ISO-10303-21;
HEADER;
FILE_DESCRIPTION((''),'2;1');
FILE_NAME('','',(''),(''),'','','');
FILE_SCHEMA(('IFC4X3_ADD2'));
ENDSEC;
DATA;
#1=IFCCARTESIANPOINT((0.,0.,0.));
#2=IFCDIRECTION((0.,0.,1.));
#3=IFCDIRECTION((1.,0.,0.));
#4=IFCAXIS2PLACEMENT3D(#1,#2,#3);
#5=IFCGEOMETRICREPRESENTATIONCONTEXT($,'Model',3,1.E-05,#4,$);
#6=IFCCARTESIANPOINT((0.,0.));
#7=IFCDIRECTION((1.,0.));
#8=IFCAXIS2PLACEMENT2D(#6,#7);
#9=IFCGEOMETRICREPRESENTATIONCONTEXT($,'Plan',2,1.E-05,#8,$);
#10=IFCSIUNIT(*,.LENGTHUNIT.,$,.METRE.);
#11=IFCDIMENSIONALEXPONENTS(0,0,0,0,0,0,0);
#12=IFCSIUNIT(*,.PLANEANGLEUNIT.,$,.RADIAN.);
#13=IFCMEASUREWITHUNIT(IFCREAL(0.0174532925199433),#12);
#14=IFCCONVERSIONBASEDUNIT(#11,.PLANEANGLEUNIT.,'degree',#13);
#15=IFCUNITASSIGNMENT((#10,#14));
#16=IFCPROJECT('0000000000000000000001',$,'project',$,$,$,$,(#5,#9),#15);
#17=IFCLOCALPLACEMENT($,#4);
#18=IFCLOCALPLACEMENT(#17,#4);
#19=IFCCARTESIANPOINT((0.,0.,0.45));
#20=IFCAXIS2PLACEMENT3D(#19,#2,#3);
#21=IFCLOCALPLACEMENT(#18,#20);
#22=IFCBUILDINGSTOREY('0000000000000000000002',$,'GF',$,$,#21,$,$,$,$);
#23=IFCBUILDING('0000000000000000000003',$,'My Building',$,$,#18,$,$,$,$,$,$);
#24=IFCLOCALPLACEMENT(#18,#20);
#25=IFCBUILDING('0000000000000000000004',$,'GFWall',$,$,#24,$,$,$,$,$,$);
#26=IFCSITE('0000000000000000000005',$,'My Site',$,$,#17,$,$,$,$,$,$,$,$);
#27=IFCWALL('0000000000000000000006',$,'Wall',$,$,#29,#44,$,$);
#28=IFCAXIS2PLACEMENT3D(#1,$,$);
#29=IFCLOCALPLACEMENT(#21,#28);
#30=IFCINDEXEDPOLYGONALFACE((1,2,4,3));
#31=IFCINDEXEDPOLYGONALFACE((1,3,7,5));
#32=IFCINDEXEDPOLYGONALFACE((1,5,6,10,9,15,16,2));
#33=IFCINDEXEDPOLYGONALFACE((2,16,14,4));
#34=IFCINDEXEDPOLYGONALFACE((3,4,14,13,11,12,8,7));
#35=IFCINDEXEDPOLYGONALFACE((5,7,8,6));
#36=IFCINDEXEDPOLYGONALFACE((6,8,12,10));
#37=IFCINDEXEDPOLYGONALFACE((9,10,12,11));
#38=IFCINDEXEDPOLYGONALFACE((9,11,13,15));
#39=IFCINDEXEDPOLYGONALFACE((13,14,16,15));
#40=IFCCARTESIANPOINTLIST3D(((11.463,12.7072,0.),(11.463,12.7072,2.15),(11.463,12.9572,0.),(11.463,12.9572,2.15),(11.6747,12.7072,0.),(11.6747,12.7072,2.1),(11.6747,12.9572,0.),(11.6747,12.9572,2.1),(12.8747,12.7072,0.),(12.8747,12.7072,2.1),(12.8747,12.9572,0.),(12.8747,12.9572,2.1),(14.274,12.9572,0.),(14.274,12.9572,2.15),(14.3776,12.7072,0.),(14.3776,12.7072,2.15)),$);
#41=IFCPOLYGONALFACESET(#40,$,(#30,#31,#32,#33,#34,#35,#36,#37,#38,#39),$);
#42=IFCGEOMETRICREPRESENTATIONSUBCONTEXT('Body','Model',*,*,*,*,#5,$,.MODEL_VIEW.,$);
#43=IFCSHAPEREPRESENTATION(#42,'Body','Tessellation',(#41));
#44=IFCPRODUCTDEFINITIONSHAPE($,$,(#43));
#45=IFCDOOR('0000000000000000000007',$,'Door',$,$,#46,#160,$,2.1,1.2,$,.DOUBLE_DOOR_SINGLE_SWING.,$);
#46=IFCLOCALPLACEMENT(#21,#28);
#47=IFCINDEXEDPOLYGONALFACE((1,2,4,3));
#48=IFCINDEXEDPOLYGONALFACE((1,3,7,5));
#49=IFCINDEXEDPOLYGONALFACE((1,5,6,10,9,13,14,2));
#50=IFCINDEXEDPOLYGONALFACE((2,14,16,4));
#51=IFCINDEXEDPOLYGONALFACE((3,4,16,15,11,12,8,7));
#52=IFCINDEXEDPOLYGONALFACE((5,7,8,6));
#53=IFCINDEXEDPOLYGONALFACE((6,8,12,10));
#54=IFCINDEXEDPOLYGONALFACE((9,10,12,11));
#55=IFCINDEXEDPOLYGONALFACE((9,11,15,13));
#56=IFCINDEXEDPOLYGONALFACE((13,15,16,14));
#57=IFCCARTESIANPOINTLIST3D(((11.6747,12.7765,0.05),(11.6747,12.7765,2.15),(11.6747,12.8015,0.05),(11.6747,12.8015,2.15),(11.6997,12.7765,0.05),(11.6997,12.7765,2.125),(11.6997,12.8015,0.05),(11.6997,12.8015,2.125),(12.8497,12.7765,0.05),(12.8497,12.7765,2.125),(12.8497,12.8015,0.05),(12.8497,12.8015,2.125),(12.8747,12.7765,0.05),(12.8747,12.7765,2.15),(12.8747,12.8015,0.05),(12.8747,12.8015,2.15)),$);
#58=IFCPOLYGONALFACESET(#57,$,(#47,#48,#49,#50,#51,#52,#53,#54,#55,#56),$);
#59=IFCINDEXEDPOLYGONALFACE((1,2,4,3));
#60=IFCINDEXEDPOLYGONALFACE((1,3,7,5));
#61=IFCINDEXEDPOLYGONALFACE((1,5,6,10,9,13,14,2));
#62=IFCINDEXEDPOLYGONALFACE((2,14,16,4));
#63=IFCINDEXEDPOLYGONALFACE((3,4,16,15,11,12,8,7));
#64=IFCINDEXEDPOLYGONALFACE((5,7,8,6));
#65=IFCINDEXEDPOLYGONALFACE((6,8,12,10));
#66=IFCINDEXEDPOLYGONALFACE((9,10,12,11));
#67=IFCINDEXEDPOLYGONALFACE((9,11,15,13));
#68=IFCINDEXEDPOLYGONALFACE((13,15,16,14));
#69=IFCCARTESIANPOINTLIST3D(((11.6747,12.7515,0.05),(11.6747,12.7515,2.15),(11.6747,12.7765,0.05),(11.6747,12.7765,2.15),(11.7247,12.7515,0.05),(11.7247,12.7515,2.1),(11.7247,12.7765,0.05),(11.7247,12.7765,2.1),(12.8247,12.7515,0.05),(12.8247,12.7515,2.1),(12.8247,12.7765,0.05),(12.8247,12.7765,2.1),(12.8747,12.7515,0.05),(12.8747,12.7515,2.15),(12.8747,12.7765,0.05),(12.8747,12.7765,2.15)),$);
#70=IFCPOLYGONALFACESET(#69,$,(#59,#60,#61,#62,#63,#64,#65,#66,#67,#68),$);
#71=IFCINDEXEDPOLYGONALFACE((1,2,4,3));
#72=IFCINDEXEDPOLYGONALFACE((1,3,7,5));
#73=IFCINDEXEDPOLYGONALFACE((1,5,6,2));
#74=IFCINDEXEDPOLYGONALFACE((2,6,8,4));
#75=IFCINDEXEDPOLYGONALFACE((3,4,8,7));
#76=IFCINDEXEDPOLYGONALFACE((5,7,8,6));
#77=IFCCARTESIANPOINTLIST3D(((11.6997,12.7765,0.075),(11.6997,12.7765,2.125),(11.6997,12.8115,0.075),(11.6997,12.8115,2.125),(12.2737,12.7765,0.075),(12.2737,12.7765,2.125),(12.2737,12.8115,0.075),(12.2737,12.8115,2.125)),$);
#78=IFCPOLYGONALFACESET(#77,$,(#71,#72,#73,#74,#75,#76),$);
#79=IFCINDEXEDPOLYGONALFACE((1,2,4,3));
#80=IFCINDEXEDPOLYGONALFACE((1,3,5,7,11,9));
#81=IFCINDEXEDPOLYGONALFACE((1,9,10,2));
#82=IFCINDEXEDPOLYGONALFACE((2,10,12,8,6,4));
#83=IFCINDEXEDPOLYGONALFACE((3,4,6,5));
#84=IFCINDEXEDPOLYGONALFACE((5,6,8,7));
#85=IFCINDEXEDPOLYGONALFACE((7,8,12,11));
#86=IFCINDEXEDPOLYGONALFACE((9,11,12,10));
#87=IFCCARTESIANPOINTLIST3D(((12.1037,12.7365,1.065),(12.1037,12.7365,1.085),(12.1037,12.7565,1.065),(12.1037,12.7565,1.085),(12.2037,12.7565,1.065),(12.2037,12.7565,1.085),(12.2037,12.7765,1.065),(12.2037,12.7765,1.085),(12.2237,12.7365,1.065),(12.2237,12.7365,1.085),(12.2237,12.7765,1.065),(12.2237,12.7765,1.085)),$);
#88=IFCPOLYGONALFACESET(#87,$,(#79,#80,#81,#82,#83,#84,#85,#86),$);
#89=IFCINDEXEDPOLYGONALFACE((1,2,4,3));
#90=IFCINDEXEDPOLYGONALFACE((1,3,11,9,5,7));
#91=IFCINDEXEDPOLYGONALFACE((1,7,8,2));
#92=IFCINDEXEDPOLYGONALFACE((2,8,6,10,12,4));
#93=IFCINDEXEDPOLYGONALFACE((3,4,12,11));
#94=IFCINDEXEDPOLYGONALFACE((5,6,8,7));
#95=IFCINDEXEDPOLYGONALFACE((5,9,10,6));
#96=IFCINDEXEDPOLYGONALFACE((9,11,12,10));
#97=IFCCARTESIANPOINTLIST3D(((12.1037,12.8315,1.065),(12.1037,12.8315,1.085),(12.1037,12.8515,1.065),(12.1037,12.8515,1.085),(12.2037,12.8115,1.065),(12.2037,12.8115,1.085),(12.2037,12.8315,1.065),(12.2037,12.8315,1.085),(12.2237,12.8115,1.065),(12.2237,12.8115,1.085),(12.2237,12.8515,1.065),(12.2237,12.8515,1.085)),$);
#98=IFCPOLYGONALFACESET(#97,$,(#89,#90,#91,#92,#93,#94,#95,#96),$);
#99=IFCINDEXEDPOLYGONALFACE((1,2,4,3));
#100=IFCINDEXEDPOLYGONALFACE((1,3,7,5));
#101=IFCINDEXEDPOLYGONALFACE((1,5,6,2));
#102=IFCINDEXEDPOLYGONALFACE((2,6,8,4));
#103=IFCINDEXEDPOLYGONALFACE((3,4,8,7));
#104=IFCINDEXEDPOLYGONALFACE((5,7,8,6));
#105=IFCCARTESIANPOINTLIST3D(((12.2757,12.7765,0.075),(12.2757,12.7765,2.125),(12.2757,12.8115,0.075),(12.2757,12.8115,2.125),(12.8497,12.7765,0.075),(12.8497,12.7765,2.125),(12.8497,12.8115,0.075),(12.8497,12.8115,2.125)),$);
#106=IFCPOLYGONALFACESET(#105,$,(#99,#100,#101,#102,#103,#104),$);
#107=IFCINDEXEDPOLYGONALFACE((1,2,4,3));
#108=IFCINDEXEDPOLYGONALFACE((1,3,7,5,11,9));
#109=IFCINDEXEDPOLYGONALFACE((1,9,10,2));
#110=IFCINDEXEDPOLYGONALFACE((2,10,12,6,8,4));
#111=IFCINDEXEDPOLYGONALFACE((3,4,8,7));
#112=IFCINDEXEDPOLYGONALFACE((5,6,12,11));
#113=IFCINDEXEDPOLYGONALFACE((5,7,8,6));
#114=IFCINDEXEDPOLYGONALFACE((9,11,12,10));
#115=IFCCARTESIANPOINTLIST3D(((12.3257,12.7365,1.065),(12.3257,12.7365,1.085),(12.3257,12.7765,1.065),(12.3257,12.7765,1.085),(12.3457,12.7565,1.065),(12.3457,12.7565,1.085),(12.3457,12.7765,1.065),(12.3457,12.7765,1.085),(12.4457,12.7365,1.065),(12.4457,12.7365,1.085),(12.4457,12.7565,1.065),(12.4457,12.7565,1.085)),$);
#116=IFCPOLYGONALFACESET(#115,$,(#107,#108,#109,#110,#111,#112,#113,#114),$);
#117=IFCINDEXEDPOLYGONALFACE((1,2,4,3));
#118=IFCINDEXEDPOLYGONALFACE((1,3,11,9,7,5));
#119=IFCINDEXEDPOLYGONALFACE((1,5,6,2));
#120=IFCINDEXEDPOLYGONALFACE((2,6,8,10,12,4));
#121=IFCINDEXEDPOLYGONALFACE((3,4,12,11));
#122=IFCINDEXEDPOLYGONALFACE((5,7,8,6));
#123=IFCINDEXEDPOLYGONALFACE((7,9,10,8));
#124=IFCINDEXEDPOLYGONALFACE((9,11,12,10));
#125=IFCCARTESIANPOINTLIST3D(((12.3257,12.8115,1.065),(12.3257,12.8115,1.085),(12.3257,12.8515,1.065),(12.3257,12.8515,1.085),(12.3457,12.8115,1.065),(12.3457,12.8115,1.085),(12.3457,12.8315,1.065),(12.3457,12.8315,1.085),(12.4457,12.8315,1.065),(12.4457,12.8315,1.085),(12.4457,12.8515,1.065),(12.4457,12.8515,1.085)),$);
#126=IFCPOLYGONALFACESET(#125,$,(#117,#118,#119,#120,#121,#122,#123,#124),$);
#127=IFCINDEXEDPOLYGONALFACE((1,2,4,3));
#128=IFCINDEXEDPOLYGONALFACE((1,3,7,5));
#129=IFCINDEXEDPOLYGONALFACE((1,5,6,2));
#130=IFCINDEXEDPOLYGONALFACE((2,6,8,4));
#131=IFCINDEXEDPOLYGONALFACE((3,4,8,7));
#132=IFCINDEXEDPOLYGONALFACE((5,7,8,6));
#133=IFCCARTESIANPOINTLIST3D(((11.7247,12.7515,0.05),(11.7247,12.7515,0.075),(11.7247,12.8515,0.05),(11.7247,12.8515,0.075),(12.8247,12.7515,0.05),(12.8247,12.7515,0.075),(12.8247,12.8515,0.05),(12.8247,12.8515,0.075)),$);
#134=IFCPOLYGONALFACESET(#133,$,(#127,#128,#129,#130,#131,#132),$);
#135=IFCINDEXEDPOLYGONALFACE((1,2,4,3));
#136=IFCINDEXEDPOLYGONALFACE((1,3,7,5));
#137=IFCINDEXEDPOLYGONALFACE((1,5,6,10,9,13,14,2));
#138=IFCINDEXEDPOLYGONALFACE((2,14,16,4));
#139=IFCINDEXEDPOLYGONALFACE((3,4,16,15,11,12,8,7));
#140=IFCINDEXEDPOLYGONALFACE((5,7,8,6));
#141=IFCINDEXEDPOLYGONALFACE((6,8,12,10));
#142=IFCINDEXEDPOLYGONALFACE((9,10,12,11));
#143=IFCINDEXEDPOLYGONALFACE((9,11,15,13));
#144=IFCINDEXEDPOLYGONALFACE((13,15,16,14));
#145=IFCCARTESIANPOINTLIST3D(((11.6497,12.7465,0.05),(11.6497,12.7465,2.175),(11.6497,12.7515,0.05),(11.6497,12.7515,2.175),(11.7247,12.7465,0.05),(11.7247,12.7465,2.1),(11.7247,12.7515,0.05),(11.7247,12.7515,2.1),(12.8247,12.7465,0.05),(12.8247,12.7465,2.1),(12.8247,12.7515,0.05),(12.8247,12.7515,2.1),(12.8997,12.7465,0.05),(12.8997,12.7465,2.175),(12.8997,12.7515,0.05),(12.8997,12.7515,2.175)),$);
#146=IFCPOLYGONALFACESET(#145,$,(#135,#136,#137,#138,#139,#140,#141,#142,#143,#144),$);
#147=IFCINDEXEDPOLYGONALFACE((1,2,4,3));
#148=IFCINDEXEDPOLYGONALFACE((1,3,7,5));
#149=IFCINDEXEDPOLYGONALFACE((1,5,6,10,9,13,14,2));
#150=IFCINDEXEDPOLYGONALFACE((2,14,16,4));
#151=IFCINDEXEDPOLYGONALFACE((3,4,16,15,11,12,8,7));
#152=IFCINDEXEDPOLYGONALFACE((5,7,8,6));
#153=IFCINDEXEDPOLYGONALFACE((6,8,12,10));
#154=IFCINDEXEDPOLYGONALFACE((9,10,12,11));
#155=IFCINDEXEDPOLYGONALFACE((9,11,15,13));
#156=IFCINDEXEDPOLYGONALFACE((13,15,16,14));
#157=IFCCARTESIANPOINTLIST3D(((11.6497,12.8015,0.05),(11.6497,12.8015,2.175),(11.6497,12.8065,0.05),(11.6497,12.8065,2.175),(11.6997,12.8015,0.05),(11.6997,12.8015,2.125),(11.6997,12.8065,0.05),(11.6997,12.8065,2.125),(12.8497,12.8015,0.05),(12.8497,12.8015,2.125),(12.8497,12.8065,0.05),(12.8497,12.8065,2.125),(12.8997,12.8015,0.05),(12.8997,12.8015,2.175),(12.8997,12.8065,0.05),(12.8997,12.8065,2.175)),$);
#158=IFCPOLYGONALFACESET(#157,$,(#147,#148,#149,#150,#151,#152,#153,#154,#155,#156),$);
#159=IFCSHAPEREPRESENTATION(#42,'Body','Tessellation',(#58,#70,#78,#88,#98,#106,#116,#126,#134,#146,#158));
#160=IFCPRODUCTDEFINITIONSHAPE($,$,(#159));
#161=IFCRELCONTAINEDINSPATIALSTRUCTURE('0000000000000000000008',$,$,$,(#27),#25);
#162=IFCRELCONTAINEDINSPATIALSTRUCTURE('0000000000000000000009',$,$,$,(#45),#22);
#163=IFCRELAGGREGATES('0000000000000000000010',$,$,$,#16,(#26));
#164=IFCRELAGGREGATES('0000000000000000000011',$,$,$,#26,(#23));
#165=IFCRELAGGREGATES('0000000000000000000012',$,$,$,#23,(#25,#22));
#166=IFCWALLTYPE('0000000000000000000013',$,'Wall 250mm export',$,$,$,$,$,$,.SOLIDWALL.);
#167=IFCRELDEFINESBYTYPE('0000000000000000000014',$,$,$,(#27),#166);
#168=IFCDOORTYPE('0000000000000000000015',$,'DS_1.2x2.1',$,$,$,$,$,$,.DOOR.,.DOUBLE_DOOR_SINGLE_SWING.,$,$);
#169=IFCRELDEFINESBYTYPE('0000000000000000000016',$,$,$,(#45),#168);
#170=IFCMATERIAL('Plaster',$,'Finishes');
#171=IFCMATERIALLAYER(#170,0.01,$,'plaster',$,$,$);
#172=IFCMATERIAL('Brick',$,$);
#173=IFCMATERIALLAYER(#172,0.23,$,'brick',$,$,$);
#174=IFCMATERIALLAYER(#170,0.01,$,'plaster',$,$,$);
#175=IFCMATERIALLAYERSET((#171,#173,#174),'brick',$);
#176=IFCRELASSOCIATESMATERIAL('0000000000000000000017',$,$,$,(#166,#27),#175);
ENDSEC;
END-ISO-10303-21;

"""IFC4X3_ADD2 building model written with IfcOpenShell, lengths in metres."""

from ifc_helpers import new_model, entity, si_unit, converted_unit, frame, origin_with_axes, origin_2d_with_axis, place, context, subcontext, project, spatial, line, indexed_curve, outline, extrude, shape, source, transform, mapped, material, layer, layer_set, layer_usage, type_object, type_shapes, element, fill, save


model = new_model("IFC4X3_ADD2")

# Units and contexts
model_context = context("Model", 3, precision=1e-05, world=origin_with_axes())
plan_context = context("Plan", 2, precision=1e-05, world=origin_2d_with_axis())
body_context_1 = subcontext(model_context, "Body", "Model", "MODEL_VIEW")
body_context_2 = subcontext(plan_context, "Body", "Plan", "PLAN_VIEW")
ifc_project = project(units=[si_unit("LENGTHUNIT", "METRE"), converted_unit("PLANEANGLEUNIT", "degree", entity("IfcReal", 0.0174532925199433), si_unit("PLANEANGLEUNIT", "RADIAN"), dimensions=[0, 0, 0, 0, 0, 0, 0])], contexts=[model_context, plan_context])

# Site, buildings
site_placement = place(None, origin_with_axes())
site = spatial("IfcSite", under=ifc_project, at=site_placement, Name="My Site")
building_1_placement = place(site_placement, origin_with_axes())
building_1 = spatial("IfcBuilding", under=site, at=building_1_placement, Name="My Building")
building_2_placement = place(building_1_placement, frame((0.0, 0.0, 0.45), z_axis=(0.0, 0.0, 1.0), x_axis=(1.0, 0.0, 0.0)))
building_2 = spatial("IfcBuilding", under=building_1, at=building_2_placement, Name="GFWall")

# Shared definitions
ifc_material_1 = material(Name="Plaster", Category="Finishes")

# Shared definitions
storey_placement = place(building_1_placement, frame((0.0, 0.0, 0.45), z_axis=(0.0, 0.0, 1.0), x_axis=(1.0, 0.0, 0.0)))
storey = spatial("IfcBuildingStorey", under=building_1, at=storey_placement, Name="GF")

# Shared definitions
ifc_layer_1 = layer(ifc_material_1, 0.01, Name="plaster")
ifc_material_2 = material(Name="Brick")
ifc_layer_2 = layer(ifc_material_2, 0.23, Name="brick")
ifc_layer_3 = layer(ifc_material_1, 0.01, Name="plaster")
ifc_layer_set_1 = layer_set([ifc_layer_1, ifc_layer_2, ifc_layer_3], Name="brick")
wall_type_1 = type_object("IfcWallType", Name="Wall 250mm export", PredefinedType="SOLIDWALL", material=ifc_layer_set_1)

# Wall, opening, door
shared_shape_1 = source(origin_with_axes(), body_context_1, "Body", "SweptSolid", [
    extrude(outline(indexed_curve([(0.0, 0.0), (1.2, 0.0), (1.2, 2.1), (0.0, 2.1)], segments=[line(1, 2, 3, 4, 1)])), frame((0.0, -0.6, 0.0), z_axis=(0.0, -1.0, 0.0), x_axis=(1.0, 0.0, 0.0)), (0.0, 0.0, -1.0), 1.2),
])
door_type_1 = type_object("IfcDoorType", Name="DS_1.2x2.1", OperationType="DOUBLE_DOOR_SINGLE_SWING", PredefinedType="DOOR")
shared_shape_2 = source(origin_with_axes(), body_context_1, "Body", "SweptSolid", [
    extrude(outline(indexed_curve([(0.0, 0.0), (0.0, 2.1), (1.2, 2.1), (1.2, 0.0), (1.175, 0.0), (1.175, 2.075), (0.025, 2.075), (0.025, 0.0)], segments=[line(1, 2, 3, 4, 5, 6, 7, 8, 1)])), frame((0.0, 0.025, 0.0), z_axis=(0.0, -1.0, 0.0), x_axis=(1.0, 0.0, 0.0)), (0.0, 0.0, -1.0), 0.025),
    extrude(outline(indexed_curve([(0.0, 0.0), (0.0, 2.1), (1.2, 2.1), (1.2, 0.0), (1.15, 0.0), (1.15, 2.05), (0.05, 2.05), (0.05, 0.0)], segments=[line(1, 2, 3, 4, 5, 6, 7, 8, 1)])), frame((0.0, 0.0, 0.0), z_axis=(0.0, -1.0, 0.0), x_axis=(1.0, 0.0, 0.0)), (0.0, 0.0, -1.0), 0.025),
    extrude(outline(indexed_curve([(0.0, 0.0), (0.574, 0.0), (0.574, 0.035), (0.0, 0.035)], segments=[line(1, 2, 3, 4, 1)])), frame((0.025, 0.025, 0.025), z_axis=(0.0, 0.0, 1.0), x_axis=(1.0, 0.0, 0.0)), (0.0, 0.0, 1.0), 2.05),
    extrude(outline(indexed_curve([(0.0, 0.0), (0.0, -0.04), (-0.12, -0.04), (-0.12, -0.02), (-0.02, -0.02), (-0.02, 0.0)], segments=[line(1, 2, 3, 4, 5, 6, 1)])), frame((0.549, 0.025, 1.015), z_axis=(0.0, 0.0, 1.0), x_axis=(1.0, 0.0, 0.0)), (0.0, 0.0, 1.0), 0.02),
    extrude(outline(indexed_curve([(0.0, 0.0), (0.0, 0.04), (-0.12, 0.04), (-0.12, 0.02), (-0.02, 0.02), (-0.02, 0.0)], segments=[line(1, 2, 3, 4, 5, 6, 1)])), frame((0.549, 0.06, 1.015), z_axis=(0.0, 0.0, 1.0), x_axis=(1.0, 0.0, 0.0)), (0.0, 0.0, 1.0), 0.02),
    extrude(outline(indexed_curve([(0.0, 0.0), (-0.574, 0.0), (-0.574, 0.035), (0.0, 0.035)], segments=[line(1, 2, 3, 4, 1)])), frame((1.175, 0.025, 0.025), z_axis=(0.0, 0.0, 1.0), x_axis=(1.0, 0.0, 0.0)), (0.0, 0.0, 1.0), 2.05),
    extrude(outline(indexed_curve([(0.0, 0.0), (0.0, -0.04), (0.12, -0.04), (0.12, -0.02), (0.02, -0.02), (0.02, 0.0)], segments=[line(1, 2, 3, 4, 5, 6, 1)])), frame((0.651, 0.025, 1.015), z_axis=(0.0, 0.0, 1.0), x_axis=(1.0, 0.0, 0.0)), (0.0, 0.0, 1.0), 0.02),
    extrude(outline(indexed_curve([(0.0, 0.0), (0.0, 0.04), (0.12, 0.04), (0.12, 0.02), (0.02, 0.02), (0.02, 0.0)], segments=[line(1, 2, 3, 4, 5, 6, 1)])), frame((0.651, 0.06, 1.015), z_axis=(0.0, 0.0, 1.0), x_axis=(1.0, 0.0, 0.0)), (0.0, 0.0, 1.0), 0.02),
    extrude(outline(indexed_curve([(0.0, 0.0), (1.1, 0.0), (1.1, 0.1), (0.0, 0.1)], segments=[line(1, 2, 3, 4, 1)])), frame((0.05, 0.0, 0.0), z_axis=(0.0, 0.0, 1.0), x_axis=(1.0, 0.0, 0.0)), (0.0, 0.0, 1.0), 0.025),
    extrude(outline(indexed_curve([(0.0, 0.0), (0.0, 2.125), (1.25, 2.125), (1.25, 0.0), (1.175, 0.0), (1.175, 2.05), (0.075, 2.05), (0.075, 0.0)], segments=[line(1, 2, 3, 4, 5, 6, 7, 8, 1)])), frame((-0.025, -0.005, 0.0), z_axis=(0.0, -1.0, 0.0), x_axis=(1.0, 0.0, 0.0)), (0.0, 0.0, -1.0), 0.005),
    extrude(outline(indexed_curve([(0.0, 0.0), (0.0, 2.125), (1.25, 2.125), (1.25, 0.0), (1.2, 0.0), (1.2, 2.075), (0.05, 2.075), (0.05, 0.0)], segments=[line(1, 2, 3, 4, 5, 6, 7, 8, 1)])), frame((-0.025, 0.05, 0.0), z_axis=(0.0, -1.0, 0.0), x_axis=(1.0, 0.0, 0.0)), (0.0, 0.0, -1.0), 0.005),
])
shared_shape_3 = source(origin_with_axes(), body_context_2, "Body", "Curve2D", [
    entity("IfcIndexedPolyCurve", entity("IfcCartesianPointList2D", [[0.0, 0.0], [0.0, 0.05], [0.025, 0.05], [0.025, 0.025], [0.05, 0.025], [0.05, 0.0]]), [entity("IfcLineIndex", [1, 2, 3, 4, 5, 6, 1])]),
    entity("IfcIndexedPolyCurve", entity("IfcCartesianPointList2D", [[1.2, 0.0], [1.2, 0.05], [1.175, 0.05], [1.175, 0.025], [1.15, 0.025], [1.15, 0.0]]), [entity("IfcLineIndex", [1, 2, 3, 4, 5, 6, 1])]),
    entity("IfcTrimmedCurve", entity("IfcEllipse", entity("IfcAxis2Placement2D", entity("IfcCartesianPoint", [0.06, 0.05]), entity("IfcDirection", [1.0, 0.0])), 0.54, 0.575), [entity("IfcCartesianPoint", [0.6, 0.05])], [entity("IfcCartesianPoint", [0.06, 0.625])], True, "CARTESIAN"),
    entity("IfcIndexedPolyCurve", entity("IfcCartesianPointList2D", [[0.025, 0.05], [0.06, 0.05], [0.06, 0.625], [0.025, 0.625]]), [entity("IfcLineIndex", [1, 2, 3, 4, 1])]),
    entity("IfcTrimmedCurve", entity("IfcEllipse", entity("IfcAxis2Placement2D", entity("IfcCartesianPoint", [1.14, 0.05]), entity("IfcDirection", [1.0, 0.0])), 0.54, 0.575), [entity("IfcCartesianPoint", [1.14, 0.625])], [entity("IfcCartesianPoint", [0.6, 0.05])], True, "CARTESIAN"),
    entity("IfcIndexedPolyCurve", entity("IfcCartesianPointList2D", [[1.175, 0.05], [1.14, 0.05], [1.14, 0.625], [1.175, 0.625]]), [entity("IfcLineIndex", [1, 2, 3, 4, 1])]),
])
type_shapes(door_type_1, [shared_shape_2, shared_shape_3])
ifc_layer_usage_1 = layer_usage(ifc_layer_set_1, "AXIS2", "POSITIVE", 0.0)
wall_1_placement = place(building_2_placement, frame((11.463, 12.7072, 0.0), z_axis=(0.0, 0.0, 1.0), x_axis=(1.0, 0.0, 0.0)))
wall_1 = element("IfcWall", 1, at=wall_1_placement, inside=building_2, type_object=wall_type_1, material=ifc_layer_usage_1, Name="Wall", context=body_context_1, shape_type="SweptSolid", body=[
    extrude(outline(indexed_curve([(0.0, 0.0), (0.0, 0.25), (2.811, 0.25), (2.9146, 0.0)], segments=[line(1, 2, 3, 4, 1)])), origin_with_axes(), (0.0, 0.0, 1.0), 2.15),
])
opening_1_placement = place(wall_1_placement, frame((0.2117, 0.0443, 0.0), z_axis=(0.0, 0.0, 1.0), x_axis=(1.0, 0.0, 0.0)))
opening_1 = element("IfcOpeningElement", 2, at=opening_1_placement, cuts=wall_1, PredefinedType="OPENING", context=body_context_1, shape_type="MappedRepresentation", body=[
    mapped(shared_shape_1, transform((0.0, 0.0, 0.0), x_axis=(1.0, 0.0, 0.0), y_axis=(0.0, 1.0, 0.0), z_axis=(0.0, 0.0, 1.0), scale=1.0)),
])
door_1_placement = place(opening_1_placement, frame((0.0, 0.0, 0.05), z_axis=(0.0, 0.0, 1.0), x_axis=(1.0, 0.0, 0.0)))
door_1 = element("IfcDoor", 3, at=door_1_placement, inside=storey, type_object=door_type_1, Name="Door", OperationType="DOUBLE_DOOR_SINGLE_SWING", OverallHeight=2.1, OverallWidth=1.2, shapes=[
    shape(body_context_1, "Body", "MappedRepresentation", [mapped(shared_shape_2, transform((0.0, 0.0, 0.0), x_axis=(1.0, 0.0, 0.0), y_axis=(0.0, 1.0, 0.0), z_axis=(0.0, 0.0, 1.0), scale=1.0))]),
    shape(body_context_2, "Body", "MappedRepresentation", [mapped(shared_shape_3, transform((0.0, 0.0, 0.0), x_axis=(1.0, 0.0, 0.0), y_axis=(0.0, 1.0, 0.0), z_axis=(0.0, 0.0, 1.0), scale=1.0))]),
])
fill(opening_1, door_1)

save(model, "model.ifc")
